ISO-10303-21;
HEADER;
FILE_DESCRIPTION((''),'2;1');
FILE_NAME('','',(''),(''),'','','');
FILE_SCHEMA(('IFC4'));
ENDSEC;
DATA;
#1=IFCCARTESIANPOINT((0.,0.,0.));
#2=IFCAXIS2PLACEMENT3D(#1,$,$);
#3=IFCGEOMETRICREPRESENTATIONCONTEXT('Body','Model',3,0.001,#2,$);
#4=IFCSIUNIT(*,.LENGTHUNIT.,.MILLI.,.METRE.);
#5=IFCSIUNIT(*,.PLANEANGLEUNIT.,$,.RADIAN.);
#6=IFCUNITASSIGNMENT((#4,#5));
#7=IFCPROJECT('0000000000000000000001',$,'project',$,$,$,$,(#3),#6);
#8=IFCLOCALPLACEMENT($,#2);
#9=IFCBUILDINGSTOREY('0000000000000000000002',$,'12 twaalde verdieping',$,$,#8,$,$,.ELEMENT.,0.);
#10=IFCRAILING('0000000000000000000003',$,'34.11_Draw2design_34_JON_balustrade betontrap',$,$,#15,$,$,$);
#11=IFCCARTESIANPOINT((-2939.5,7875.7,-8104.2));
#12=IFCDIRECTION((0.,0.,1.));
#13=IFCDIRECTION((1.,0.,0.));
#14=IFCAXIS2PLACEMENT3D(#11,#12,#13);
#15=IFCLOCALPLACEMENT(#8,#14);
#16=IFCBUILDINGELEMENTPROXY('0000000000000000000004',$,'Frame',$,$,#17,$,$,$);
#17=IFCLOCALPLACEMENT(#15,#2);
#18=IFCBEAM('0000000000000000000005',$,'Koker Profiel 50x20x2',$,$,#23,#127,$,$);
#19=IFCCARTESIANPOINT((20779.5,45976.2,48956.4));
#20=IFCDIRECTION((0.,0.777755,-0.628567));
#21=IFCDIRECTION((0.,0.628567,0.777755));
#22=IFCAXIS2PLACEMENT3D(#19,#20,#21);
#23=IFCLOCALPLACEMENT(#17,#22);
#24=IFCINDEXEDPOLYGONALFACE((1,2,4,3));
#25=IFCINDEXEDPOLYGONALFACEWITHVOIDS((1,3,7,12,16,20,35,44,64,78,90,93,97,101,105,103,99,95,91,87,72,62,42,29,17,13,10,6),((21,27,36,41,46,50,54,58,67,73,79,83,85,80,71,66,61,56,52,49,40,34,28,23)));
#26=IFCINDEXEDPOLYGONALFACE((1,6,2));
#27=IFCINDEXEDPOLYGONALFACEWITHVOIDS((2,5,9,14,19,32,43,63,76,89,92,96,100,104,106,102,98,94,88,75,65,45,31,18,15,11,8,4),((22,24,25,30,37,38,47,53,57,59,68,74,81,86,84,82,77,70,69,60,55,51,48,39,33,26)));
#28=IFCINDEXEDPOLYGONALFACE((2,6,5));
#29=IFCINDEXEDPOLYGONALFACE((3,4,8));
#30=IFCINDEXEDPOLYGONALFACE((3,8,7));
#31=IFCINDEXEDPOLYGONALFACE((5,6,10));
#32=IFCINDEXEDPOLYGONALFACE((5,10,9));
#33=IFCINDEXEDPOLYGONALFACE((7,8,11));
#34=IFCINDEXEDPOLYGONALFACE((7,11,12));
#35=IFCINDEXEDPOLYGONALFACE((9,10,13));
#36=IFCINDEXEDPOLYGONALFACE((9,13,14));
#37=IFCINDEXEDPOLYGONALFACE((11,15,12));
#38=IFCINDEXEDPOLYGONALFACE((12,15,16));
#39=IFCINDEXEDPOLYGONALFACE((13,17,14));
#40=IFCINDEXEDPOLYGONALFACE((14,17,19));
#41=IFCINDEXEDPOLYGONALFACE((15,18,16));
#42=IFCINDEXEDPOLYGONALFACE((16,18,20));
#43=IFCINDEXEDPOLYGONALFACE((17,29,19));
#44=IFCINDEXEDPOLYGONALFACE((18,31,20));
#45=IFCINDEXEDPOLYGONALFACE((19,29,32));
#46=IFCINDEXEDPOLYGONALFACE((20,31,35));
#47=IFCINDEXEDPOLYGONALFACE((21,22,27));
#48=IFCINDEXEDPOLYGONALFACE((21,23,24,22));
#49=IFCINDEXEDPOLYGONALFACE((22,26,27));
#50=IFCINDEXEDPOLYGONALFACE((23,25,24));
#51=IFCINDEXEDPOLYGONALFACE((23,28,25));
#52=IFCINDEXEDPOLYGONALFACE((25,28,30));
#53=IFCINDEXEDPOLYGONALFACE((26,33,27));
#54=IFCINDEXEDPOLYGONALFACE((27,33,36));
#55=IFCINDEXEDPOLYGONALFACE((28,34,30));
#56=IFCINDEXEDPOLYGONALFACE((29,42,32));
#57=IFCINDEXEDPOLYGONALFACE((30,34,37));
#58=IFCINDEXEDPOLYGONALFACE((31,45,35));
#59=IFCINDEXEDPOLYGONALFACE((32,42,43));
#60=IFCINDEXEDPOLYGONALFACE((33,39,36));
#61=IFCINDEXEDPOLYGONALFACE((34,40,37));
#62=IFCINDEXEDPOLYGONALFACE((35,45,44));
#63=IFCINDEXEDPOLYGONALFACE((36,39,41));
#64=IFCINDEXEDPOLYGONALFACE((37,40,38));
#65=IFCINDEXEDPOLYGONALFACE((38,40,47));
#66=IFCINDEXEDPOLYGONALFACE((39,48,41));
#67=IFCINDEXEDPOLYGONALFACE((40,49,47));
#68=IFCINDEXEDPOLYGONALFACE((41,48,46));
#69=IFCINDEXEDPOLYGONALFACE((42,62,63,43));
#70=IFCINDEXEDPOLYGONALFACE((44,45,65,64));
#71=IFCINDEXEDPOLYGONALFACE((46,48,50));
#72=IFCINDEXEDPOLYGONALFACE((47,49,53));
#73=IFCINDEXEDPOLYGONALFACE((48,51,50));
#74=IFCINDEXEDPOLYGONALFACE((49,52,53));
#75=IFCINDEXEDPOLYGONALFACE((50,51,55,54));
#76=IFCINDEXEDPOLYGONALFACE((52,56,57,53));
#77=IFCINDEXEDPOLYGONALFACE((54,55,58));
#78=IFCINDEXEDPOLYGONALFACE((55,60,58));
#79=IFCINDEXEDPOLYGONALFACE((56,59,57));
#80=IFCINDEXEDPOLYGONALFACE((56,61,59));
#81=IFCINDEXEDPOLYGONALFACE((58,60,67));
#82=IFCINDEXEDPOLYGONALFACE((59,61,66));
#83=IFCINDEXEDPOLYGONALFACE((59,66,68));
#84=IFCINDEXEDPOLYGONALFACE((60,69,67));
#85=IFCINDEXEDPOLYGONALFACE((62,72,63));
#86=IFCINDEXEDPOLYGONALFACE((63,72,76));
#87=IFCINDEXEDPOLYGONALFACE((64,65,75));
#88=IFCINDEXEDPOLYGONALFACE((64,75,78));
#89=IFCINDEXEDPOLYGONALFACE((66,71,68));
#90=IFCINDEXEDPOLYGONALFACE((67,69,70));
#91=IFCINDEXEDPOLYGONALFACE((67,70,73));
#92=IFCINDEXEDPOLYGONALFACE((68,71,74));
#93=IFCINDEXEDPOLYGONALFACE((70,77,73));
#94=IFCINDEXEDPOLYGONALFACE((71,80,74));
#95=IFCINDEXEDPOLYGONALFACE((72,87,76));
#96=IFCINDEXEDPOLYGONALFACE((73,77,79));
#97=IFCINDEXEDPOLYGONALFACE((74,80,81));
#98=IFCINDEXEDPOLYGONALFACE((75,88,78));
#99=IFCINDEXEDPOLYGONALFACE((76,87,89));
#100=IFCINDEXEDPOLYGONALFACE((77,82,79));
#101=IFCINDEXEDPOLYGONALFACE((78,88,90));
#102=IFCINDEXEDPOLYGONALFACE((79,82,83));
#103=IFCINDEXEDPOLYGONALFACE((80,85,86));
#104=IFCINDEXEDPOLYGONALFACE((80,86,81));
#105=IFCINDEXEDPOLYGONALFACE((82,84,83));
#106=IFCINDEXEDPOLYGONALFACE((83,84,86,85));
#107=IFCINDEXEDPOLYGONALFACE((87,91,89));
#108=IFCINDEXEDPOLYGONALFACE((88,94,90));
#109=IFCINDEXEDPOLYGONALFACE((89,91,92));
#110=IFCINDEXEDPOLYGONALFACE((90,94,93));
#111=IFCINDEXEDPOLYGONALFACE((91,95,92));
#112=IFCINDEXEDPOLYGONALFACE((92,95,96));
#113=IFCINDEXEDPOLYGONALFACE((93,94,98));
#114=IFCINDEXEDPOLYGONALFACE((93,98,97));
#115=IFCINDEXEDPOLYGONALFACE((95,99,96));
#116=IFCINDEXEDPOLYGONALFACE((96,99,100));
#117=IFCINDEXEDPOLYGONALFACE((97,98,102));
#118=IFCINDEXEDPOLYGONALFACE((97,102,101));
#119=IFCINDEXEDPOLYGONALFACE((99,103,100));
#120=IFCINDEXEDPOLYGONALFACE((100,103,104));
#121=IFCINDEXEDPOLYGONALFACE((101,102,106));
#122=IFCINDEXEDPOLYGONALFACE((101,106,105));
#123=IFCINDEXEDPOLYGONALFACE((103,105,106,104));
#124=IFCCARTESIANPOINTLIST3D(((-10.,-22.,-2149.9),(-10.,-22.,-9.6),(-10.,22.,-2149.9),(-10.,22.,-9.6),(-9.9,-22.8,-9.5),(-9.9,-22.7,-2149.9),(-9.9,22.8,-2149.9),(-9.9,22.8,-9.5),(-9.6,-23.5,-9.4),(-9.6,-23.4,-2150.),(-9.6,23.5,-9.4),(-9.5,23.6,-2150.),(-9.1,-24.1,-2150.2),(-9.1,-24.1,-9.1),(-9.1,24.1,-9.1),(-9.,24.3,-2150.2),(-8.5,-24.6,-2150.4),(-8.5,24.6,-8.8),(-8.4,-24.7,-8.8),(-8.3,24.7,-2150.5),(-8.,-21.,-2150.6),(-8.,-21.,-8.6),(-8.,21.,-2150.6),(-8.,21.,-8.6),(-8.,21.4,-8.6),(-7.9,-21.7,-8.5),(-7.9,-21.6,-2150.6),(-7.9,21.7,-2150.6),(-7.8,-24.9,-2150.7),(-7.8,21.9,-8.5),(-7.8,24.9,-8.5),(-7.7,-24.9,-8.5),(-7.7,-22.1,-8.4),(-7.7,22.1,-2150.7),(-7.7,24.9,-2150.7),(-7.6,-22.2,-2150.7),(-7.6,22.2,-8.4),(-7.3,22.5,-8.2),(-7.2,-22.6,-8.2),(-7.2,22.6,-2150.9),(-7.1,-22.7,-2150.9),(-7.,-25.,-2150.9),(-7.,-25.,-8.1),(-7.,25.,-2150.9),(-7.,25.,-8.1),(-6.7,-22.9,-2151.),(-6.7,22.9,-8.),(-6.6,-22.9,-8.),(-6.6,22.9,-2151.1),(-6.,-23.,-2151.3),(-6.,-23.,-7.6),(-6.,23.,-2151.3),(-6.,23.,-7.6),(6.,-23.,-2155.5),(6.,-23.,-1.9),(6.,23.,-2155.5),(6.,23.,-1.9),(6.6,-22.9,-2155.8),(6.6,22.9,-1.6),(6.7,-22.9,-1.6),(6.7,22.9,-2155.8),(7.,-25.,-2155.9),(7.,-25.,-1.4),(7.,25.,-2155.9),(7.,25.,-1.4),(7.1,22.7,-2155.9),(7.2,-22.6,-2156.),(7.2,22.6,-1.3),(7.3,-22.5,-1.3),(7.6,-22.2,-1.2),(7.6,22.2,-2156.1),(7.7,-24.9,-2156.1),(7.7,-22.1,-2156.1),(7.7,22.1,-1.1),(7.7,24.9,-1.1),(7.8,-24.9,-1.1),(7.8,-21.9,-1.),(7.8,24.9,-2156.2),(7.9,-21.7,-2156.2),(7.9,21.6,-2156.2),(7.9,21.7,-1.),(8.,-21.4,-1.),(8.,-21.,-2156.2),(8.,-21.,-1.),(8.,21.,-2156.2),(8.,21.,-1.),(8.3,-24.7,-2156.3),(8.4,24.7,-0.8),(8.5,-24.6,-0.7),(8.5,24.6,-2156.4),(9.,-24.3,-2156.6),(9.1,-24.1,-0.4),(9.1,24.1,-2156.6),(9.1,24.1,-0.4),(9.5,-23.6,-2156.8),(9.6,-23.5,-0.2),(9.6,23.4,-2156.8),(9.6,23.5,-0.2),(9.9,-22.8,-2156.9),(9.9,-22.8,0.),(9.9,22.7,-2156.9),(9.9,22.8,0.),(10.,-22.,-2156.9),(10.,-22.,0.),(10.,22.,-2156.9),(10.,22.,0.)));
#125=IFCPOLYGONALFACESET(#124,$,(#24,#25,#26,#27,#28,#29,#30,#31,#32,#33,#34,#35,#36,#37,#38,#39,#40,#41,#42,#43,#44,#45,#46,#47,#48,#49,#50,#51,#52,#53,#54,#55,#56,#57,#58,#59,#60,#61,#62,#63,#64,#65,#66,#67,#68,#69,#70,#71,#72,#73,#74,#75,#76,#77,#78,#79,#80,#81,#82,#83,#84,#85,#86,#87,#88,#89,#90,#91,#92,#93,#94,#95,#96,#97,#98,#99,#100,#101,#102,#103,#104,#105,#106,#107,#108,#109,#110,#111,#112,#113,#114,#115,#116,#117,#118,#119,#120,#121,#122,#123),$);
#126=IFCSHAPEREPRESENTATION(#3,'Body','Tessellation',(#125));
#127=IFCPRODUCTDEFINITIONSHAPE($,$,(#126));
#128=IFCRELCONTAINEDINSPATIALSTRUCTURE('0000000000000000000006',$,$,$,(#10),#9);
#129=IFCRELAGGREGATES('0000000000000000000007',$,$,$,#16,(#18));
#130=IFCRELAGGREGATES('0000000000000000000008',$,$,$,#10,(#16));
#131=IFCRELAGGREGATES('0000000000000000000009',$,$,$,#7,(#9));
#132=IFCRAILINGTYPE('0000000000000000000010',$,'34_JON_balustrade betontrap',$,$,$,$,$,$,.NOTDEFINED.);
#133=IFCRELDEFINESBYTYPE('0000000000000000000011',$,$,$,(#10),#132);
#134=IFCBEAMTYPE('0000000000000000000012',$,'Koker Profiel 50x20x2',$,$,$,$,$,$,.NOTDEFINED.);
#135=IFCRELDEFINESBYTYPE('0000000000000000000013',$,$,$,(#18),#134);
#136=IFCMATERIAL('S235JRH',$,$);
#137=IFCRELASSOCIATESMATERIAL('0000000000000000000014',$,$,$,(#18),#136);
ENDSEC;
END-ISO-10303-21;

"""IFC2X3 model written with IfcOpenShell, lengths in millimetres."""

from ifc_helpers import new_model, si_unit, frame, origin, origin_2d, place, context, project, spatial, hollow_rectangle, extrude, clip, halfspace, source, transform, mapped, material, type_object, element, aggregate, save


model = new_model("IFC2X3")

# Units and contexts
model_context = context("Model", 3, precision=0.001, world=origin(), identifier="Body")
ifc_project = project(units=[si_unit("LENGTHUNIT", "METRE", prefix="MILLI"), si_unit("PLANEANGLEUNIT", "RADIAN")], contexts=[model_context])

# Storey
storey_placement = place(None, origin())
storey = spatial("IfcBuildingStorey", under=ifc_project, at=storey_placement, Name="12 twaalde verdieping", CompositionType="ELEMENT", Elevation=0.0)

# Railing, building element proxy, beam
railing_type = type_object("IfcRailingType", Name="34_JON_balustrade betontrap")
railing_placement = place(storey_placement, frame((-2939.5, 7875.7, -8104.2), z_axis=(0.0, 0.0, 1.0), x_axis=(1.0, 0.0, 0.0)))
railing = element("IfcRailing", 1, at=railing_placement, inside=storey, type_object=railing_type, Name="34.11_Draw2design_34_JON_balustrade betontrap")
ifc_material_1 = material(Name="S235JRH")
proxy_1_placement = place(railing_placement, origin())
proxy_1 = element("IfcBuildingElementProxy", 2, at=proxy_1_placement, Name="Frame")
beam_type_1 = type_object("IfcBeamType", Name="Koker Profiel 50x20x2")
shared_shape_1 = source(origin(), model_context, "Body", "Clipping", [
    clip(clip(extrude(hollow_rectangle(XDim=20.0, YDim=50.0, WallThickness=2.0, InnerFilletRadius=2.0, OuterFilletRadius=3.0, at=origin_2d()), origin(), (0.0, 0.0, -1.0), 2156.9), halfspace(frame((-10.0, 25.0, -9.6), z_axis=(-0.430948, 0.0, 0.902377), x_axis=(-0.902377, 0.0, -0.430948)), False)), halfspace(frame((-10.0, -25.0, -2149.9), z_axis=(-0.33335, 0.0, -0.942803), x_axis=(0.0, -1.0, 0.0)), False)),
])
beam_1_placement = place(proxy_1_placement, frame((20779.5, 45976.2, 48956.4), z_axis=(0.0, 0.777755, -0.628567), x_axis=(0.0, 0.628567, 0.777755)))
beam_1 = element("IfcBeam", 3, at=beam_1_placement, type_object=beam_type_1, material=ifc_material_1, Name="Koker Profiel 50x20x2", context=model_context, shape_type="MappedRepresentation", body=[
    mapped(shared_shape_1, transform((0.0, 0.0, 0.0), scale=1.0)),
])
aggregate(proxy_1, [beam_1])
aggregate(railing, [proxy_1])

save(model, "model.ifc")
